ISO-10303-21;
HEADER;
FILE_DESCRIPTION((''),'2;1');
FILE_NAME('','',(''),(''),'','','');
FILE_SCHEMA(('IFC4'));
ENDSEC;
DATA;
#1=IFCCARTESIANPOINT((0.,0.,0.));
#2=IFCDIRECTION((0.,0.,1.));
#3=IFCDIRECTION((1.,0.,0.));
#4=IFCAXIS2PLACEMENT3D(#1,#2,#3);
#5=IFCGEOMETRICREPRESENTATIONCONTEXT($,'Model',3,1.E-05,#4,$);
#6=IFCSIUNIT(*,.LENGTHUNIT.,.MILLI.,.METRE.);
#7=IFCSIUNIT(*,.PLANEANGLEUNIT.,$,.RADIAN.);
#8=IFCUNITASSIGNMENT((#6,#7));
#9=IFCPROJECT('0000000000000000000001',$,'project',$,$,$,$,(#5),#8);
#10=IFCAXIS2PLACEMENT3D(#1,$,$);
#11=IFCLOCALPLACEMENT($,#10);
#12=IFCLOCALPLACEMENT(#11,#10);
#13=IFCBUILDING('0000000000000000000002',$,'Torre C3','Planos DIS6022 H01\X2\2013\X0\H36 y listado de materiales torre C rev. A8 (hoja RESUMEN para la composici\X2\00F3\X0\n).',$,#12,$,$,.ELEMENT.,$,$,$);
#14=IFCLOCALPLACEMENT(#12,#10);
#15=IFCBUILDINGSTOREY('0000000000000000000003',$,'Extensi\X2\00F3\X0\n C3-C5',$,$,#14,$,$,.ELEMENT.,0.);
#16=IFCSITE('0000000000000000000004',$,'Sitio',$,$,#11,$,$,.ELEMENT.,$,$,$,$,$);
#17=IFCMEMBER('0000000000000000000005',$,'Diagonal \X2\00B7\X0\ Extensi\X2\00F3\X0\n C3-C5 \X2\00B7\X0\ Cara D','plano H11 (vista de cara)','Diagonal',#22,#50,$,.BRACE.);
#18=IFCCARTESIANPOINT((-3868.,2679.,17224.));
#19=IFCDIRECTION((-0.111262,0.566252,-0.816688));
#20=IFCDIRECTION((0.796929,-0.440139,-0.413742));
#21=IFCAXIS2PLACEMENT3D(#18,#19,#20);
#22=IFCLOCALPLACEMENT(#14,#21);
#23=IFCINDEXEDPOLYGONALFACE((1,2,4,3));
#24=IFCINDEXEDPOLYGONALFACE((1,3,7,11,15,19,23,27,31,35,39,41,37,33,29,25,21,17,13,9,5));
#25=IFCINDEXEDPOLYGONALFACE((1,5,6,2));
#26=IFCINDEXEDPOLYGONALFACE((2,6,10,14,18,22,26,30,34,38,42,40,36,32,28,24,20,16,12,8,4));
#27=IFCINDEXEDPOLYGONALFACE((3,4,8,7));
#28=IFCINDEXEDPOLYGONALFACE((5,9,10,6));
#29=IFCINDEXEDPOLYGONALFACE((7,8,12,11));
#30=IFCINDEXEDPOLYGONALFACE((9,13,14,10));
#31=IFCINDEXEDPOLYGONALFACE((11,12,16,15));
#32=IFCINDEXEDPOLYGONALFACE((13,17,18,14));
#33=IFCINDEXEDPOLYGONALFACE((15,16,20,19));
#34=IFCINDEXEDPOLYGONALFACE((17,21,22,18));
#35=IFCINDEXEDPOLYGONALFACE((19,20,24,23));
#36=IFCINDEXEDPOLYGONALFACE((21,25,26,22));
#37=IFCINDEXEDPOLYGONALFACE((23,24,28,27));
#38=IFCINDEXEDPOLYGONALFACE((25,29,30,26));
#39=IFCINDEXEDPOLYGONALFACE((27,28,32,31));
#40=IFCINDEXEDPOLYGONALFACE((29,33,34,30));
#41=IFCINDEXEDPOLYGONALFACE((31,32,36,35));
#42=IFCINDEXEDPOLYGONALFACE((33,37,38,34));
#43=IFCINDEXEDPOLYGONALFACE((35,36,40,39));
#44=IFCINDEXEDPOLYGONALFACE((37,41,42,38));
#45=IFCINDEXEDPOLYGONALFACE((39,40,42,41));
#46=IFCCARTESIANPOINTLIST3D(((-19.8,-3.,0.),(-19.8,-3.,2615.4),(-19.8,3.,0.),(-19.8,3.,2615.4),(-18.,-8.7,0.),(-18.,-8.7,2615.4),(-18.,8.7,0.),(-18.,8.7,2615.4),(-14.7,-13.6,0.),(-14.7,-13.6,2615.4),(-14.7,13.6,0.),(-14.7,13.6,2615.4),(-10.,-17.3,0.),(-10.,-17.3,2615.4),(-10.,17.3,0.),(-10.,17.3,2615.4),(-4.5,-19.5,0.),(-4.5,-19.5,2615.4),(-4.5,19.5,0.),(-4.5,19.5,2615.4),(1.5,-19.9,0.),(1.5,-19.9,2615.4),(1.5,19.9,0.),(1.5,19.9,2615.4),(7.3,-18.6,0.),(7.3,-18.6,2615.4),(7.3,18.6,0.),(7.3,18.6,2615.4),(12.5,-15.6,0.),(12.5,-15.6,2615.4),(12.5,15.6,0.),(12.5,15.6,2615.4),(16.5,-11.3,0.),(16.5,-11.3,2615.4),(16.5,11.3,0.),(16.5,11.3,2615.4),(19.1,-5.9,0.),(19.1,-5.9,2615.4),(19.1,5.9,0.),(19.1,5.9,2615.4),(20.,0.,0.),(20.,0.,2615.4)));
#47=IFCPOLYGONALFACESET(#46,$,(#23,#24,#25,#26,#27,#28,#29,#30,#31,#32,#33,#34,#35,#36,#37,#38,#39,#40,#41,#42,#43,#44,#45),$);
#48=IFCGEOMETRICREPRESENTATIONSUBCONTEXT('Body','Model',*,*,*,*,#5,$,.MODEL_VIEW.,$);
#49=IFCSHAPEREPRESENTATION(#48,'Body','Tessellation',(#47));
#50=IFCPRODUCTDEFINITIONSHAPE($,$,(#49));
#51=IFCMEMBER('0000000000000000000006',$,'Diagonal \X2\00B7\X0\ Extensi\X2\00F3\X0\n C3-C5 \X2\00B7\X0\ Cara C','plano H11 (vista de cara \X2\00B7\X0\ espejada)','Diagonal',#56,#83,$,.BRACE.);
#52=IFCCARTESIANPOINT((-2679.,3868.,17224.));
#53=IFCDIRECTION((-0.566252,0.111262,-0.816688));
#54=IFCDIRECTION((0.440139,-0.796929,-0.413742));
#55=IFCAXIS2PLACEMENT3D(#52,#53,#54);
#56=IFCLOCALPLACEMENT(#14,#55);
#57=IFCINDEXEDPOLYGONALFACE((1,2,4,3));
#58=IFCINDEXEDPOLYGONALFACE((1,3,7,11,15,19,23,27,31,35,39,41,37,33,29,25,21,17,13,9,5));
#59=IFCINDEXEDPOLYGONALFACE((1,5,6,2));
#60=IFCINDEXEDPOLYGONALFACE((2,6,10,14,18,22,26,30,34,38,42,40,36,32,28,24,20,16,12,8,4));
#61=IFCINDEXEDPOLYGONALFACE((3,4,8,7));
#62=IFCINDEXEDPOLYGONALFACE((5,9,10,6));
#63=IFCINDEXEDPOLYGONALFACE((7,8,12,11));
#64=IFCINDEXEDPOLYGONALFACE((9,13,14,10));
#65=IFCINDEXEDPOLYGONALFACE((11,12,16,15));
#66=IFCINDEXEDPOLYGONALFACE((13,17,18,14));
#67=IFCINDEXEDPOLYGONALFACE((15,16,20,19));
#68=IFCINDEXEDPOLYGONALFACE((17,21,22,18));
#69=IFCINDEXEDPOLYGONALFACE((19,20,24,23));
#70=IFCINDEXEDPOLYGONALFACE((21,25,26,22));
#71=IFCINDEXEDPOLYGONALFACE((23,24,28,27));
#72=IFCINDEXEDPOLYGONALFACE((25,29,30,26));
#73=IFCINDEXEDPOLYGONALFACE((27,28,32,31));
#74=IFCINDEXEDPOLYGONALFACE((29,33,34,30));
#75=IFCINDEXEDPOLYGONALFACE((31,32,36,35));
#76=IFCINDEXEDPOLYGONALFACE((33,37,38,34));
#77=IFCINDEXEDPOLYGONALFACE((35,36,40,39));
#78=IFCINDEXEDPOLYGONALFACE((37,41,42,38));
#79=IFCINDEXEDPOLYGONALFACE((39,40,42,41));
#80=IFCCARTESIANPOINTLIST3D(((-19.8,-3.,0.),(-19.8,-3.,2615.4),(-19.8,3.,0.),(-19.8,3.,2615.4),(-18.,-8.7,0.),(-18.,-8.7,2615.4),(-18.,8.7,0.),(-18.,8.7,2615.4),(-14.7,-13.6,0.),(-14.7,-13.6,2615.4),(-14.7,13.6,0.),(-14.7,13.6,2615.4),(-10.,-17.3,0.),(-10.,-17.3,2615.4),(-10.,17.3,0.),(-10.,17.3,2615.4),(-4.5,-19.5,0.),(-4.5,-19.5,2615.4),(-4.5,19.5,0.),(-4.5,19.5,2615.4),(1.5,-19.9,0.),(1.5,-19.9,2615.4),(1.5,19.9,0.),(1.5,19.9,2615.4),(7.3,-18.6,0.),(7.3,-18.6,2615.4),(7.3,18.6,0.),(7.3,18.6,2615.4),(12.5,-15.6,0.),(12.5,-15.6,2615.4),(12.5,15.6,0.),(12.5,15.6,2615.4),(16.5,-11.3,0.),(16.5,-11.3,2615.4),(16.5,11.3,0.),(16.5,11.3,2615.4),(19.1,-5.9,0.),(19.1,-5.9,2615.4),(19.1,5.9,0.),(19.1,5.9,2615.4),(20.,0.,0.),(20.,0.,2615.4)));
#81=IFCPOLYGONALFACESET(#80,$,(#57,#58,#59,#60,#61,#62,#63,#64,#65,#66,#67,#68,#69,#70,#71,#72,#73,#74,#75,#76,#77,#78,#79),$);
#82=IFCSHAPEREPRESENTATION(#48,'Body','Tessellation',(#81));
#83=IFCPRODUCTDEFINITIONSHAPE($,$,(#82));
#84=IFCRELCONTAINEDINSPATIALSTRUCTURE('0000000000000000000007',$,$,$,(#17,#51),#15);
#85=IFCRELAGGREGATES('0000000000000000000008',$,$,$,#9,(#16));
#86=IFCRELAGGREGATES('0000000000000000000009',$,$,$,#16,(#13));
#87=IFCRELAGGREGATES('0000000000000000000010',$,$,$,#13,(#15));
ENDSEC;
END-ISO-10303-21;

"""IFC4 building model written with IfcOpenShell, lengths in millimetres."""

from ifc_helpers import new_model, si_unit, frame, origin, origin_with_axes, place, context, subcontext, project, spatial, circle, extrude, element, save


model = new_model("IFC4")

# Units and contexts
model_context = context("Model", 3, precision=1e-05, world=origin_with_axes())
body_context = subcontext(model_context, "Body", "Model", "MODEL_VIEW")
ifc_project = project(units=[si_unit("LENGTHUNIT", "METRE", prefix="MILLI"), si_unit("PLANEANGLEUNIT", "RADIAN")], contexts=[model_context])

# Site, building, storey
site_placement = place(None, origin())
site = spatial("IfcSite", under=ifc_project, at=site_placement, Name="Sitio", CompositionType="ELEMENT")
building_placement = place(site_placement, origin())
building = spatial("IfcBuilding", under=site, at=building_placement, Name="Torre C3", Description="Planos DIS6022 H01–H36 y listado de materiales torre C rev. A8 (hoja RESUMEN para la composición).", CompositionType="ELEMENT")
storey_placement = place(building_placement, origin())
storey = spatial("IfcBuildingStorey", under=building, at=storey_placement, Name="Extensión C3-C5", CompositionType="ELEMENT", Elevation=0.0)

# Members
for number, where, z_axis, x_axis, name, description in (
    (1, (-3868.0, 2679.0, 17224.0), (-0.111262, 0.566252, -0.816688), (0.796929, -0.440139, -0.413742), "Diagonal · Extensión C3-C5 · Cara D", "plano H11 (vista de cara)"),
    (2, (-2679.0, 3868.0, 17224.0), (-0.566252, 0.111262, -0.816688), (0.440139, -0.796929, -0.413742), "Diagonal · Extensión C3-C5 · Cara C", "plano H11 (vista de cara · espejada)"),
):
    element("IfcMember", number, at=place(storey_placement, frame(where, z_axis=z_axis, x_axis=x_axis)), inside=storey, Name=name, Description=description, ObjectType="Diagonal", PredefinedType="BRACE", context=body_context, shape_type="SweptSolid", body=[
        extrude(circle(Radius=20.0), None, (0.0, 0.0, 1.0), 2615.4),
    ])

save(model, "model.ifc")
